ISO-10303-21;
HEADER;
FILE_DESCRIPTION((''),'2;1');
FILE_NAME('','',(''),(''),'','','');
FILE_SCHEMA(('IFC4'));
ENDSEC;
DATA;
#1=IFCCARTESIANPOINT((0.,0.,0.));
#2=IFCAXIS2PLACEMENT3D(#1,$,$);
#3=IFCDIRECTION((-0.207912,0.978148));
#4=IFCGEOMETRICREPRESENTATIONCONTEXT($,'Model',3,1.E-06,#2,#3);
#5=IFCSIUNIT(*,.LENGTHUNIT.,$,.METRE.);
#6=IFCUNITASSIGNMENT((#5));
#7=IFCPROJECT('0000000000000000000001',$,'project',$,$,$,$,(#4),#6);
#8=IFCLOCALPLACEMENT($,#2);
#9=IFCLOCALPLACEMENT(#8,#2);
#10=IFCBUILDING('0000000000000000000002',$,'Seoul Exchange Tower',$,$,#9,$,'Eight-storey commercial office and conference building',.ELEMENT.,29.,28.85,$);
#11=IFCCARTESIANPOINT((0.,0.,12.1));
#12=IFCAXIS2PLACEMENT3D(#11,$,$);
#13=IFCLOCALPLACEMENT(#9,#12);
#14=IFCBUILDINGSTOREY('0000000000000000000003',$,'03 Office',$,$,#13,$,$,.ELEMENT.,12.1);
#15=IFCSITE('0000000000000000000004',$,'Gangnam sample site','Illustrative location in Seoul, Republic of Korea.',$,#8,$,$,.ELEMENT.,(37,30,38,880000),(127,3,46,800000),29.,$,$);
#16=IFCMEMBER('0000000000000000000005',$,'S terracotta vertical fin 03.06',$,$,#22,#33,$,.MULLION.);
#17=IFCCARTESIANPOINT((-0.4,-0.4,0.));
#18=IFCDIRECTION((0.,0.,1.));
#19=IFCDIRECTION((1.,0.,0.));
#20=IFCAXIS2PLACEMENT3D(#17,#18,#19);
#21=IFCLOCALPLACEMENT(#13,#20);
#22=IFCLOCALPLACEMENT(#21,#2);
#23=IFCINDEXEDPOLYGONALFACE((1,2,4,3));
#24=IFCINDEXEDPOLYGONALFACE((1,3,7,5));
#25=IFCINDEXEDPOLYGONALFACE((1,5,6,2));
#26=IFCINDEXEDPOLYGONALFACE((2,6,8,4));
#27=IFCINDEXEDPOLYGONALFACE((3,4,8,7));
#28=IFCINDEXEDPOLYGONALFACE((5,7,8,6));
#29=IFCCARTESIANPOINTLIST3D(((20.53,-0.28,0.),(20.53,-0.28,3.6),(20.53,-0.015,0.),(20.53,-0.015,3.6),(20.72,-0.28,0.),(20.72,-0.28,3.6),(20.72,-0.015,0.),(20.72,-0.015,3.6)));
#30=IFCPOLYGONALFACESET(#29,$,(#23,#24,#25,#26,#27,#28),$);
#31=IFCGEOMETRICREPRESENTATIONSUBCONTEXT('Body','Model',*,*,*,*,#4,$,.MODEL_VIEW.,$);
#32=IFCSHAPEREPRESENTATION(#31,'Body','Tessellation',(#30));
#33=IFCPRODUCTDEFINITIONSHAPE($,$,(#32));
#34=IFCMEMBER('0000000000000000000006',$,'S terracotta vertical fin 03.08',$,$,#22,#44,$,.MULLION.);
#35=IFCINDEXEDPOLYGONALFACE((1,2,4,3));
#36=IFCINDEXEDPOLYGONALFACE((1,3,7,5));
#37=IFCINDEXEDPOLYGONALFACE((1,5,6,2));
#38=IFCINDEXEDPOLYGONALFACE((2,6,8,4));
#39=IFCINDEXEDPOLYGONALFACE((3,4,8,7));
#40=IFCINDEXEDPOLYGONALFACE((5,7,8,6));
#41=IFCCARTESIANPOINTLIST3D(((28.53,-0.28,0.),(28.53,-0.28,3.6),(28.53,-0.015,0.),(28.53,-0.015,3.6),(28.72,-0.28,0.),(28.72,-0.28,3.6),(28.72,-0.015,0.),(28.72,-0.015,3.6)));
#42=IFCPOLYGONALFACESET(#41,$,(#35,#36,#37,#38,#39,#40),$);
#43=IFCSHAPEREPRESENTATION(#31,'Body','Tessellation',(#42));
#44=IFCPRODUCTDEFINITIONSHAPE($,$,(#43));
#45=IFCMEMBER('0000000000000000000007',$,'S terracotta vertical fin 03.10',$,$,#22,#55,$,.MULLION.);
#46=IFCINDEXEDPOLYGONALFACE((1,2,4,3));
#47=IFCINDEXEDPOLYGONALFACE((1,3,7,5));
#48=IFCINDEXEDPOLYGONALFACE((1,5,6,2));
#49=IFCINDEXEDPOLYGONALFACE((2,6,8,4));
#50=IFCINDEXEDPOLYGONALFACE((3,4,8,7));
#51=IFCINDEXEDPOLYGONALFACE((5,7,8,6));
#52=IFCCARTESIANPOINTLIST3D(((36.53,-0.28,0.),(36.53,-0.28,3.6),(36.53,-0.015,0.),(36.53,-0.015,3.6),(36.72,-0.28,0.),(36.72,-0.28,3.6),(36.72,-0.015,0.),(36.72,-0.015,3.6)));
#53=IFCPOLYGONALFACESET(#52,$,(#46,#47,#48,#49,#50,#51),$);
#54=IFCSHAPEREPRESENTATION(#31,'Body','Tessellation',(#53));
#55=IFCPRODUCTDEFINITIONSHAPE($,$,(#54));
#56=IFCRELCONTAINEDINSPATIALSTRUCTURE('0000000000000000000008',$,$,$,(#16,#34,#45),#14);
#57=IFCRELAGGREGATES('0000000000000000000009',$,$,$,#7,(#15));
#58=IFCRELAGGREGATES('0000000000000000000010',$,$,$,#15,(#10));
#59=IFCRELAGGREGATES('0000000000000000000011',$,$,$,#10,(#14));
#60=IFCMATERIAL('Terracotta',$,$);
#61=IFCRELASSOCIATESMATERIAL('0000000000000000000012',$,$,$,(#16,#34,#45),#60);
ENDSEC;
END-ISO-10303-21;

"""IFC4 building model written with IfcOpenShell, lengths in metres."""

from ifc_helpers import new_model, si_unit, direction, frame, frame_2d, origin, place, context, subcontext, project, spatial, rectangle, extrude, material, element, save


model = new_model("IFC4")

# Units and contexts
model_context = context("Model", 3, precision=1e-06, world=origin(), true_north=direction((-0.207912, 0.978148)))
body_context = subcontext(model_context, "Body", "Model", "MODEL_VIEW")
ifc_project = project(units=[si_unit("LENGTHUNIT", "METRE")], contexts=[model_context])

# Site, building, storey
site_placement = place(None, origin())
site = spatial("IfcSite", under=ifc_project, at=site_placement, Name="Gangnam sample site", Description="Illustrative location in Seoul, Republic of Korea.", CompositionType="ELEMENT", RefLatitude=(37, 30, 38, 880000), RefLongitude=(127, 3, 46, 800000), RefElevation=29.0)
building_placement = place(site_placement, origin())
building = spatial("IfcBuilding", under=site, at=building_placement, Name="Seoul Exchange Tower", LongName="Eight-storey commercial office and conference building", CompositionType="ELEMENT", ElevationOfRefHeight=29.0, ElevationOfTerrain=28.85)
storey_placement = place(building_placement, frame((0.0, 0.0, 12.1)))
storey = spatial("IfcBuildingStorey", under=building, at=storey_placement, Name="03 Office", CompositionType="ELEMENT", Elevation=12.1)

# Members
ifc_material_1 = material(Name="Terracotta")
placement_1 = place(storey_placement, frame((-0.4, -0.4, 0.0), z_axis=(0.0, 0.0, 1.0), x_axis=(1.0, 0.0, 0.0)))
placement_2 = place(placement_1, origin())
element("IfcMember", 1, at=placement_2, inside=storey, material=ifc_material_1, Name="S terracotta vertical fin 03.06", PredefinedType="MULLION", context=body_context, shape_type="SweptSolid", body=[
    extrude(rectangle(XDim=0.19, YDim=0.265, at=frame_2d((0.095, 0.1325))), frame((20.53, -0.28, 0.0)), (0.0, 0.0, 1.0), 3.6),
])
element("IfcMember", 2, at=placement_2, inside=storey, material=ifc_material_1, Name="S terracotta vertical fin 03.08", PredefinedType="MULLION", context=body_context, shape_type="SweptSolid", body=[
    extrude(rectangle(XDim=0.19, YDim=0.265, at=frame_2d((0.095, 0.1325))), frame((28.53, -0.28, 0.0)), (0.0, 0.0, 1.0), 3.6),
])
element("IfcMember", 3, at=placement_2, inside=storey, material=ifc_material_1, Name="S terracotta vertical fin 03.10", PredefinedType="MULLION", context=body_context, shape_type="SweptSolid", body=[
    extrude(rectangle(XDim=0.19, YDim=0.265, at=frame_2d((0.095, 0.1325))), frame((36.53, -0.28, 0.0)), (0.0, 0.0, 1.0), 3.6),
])

save(model, "model.ifc")
